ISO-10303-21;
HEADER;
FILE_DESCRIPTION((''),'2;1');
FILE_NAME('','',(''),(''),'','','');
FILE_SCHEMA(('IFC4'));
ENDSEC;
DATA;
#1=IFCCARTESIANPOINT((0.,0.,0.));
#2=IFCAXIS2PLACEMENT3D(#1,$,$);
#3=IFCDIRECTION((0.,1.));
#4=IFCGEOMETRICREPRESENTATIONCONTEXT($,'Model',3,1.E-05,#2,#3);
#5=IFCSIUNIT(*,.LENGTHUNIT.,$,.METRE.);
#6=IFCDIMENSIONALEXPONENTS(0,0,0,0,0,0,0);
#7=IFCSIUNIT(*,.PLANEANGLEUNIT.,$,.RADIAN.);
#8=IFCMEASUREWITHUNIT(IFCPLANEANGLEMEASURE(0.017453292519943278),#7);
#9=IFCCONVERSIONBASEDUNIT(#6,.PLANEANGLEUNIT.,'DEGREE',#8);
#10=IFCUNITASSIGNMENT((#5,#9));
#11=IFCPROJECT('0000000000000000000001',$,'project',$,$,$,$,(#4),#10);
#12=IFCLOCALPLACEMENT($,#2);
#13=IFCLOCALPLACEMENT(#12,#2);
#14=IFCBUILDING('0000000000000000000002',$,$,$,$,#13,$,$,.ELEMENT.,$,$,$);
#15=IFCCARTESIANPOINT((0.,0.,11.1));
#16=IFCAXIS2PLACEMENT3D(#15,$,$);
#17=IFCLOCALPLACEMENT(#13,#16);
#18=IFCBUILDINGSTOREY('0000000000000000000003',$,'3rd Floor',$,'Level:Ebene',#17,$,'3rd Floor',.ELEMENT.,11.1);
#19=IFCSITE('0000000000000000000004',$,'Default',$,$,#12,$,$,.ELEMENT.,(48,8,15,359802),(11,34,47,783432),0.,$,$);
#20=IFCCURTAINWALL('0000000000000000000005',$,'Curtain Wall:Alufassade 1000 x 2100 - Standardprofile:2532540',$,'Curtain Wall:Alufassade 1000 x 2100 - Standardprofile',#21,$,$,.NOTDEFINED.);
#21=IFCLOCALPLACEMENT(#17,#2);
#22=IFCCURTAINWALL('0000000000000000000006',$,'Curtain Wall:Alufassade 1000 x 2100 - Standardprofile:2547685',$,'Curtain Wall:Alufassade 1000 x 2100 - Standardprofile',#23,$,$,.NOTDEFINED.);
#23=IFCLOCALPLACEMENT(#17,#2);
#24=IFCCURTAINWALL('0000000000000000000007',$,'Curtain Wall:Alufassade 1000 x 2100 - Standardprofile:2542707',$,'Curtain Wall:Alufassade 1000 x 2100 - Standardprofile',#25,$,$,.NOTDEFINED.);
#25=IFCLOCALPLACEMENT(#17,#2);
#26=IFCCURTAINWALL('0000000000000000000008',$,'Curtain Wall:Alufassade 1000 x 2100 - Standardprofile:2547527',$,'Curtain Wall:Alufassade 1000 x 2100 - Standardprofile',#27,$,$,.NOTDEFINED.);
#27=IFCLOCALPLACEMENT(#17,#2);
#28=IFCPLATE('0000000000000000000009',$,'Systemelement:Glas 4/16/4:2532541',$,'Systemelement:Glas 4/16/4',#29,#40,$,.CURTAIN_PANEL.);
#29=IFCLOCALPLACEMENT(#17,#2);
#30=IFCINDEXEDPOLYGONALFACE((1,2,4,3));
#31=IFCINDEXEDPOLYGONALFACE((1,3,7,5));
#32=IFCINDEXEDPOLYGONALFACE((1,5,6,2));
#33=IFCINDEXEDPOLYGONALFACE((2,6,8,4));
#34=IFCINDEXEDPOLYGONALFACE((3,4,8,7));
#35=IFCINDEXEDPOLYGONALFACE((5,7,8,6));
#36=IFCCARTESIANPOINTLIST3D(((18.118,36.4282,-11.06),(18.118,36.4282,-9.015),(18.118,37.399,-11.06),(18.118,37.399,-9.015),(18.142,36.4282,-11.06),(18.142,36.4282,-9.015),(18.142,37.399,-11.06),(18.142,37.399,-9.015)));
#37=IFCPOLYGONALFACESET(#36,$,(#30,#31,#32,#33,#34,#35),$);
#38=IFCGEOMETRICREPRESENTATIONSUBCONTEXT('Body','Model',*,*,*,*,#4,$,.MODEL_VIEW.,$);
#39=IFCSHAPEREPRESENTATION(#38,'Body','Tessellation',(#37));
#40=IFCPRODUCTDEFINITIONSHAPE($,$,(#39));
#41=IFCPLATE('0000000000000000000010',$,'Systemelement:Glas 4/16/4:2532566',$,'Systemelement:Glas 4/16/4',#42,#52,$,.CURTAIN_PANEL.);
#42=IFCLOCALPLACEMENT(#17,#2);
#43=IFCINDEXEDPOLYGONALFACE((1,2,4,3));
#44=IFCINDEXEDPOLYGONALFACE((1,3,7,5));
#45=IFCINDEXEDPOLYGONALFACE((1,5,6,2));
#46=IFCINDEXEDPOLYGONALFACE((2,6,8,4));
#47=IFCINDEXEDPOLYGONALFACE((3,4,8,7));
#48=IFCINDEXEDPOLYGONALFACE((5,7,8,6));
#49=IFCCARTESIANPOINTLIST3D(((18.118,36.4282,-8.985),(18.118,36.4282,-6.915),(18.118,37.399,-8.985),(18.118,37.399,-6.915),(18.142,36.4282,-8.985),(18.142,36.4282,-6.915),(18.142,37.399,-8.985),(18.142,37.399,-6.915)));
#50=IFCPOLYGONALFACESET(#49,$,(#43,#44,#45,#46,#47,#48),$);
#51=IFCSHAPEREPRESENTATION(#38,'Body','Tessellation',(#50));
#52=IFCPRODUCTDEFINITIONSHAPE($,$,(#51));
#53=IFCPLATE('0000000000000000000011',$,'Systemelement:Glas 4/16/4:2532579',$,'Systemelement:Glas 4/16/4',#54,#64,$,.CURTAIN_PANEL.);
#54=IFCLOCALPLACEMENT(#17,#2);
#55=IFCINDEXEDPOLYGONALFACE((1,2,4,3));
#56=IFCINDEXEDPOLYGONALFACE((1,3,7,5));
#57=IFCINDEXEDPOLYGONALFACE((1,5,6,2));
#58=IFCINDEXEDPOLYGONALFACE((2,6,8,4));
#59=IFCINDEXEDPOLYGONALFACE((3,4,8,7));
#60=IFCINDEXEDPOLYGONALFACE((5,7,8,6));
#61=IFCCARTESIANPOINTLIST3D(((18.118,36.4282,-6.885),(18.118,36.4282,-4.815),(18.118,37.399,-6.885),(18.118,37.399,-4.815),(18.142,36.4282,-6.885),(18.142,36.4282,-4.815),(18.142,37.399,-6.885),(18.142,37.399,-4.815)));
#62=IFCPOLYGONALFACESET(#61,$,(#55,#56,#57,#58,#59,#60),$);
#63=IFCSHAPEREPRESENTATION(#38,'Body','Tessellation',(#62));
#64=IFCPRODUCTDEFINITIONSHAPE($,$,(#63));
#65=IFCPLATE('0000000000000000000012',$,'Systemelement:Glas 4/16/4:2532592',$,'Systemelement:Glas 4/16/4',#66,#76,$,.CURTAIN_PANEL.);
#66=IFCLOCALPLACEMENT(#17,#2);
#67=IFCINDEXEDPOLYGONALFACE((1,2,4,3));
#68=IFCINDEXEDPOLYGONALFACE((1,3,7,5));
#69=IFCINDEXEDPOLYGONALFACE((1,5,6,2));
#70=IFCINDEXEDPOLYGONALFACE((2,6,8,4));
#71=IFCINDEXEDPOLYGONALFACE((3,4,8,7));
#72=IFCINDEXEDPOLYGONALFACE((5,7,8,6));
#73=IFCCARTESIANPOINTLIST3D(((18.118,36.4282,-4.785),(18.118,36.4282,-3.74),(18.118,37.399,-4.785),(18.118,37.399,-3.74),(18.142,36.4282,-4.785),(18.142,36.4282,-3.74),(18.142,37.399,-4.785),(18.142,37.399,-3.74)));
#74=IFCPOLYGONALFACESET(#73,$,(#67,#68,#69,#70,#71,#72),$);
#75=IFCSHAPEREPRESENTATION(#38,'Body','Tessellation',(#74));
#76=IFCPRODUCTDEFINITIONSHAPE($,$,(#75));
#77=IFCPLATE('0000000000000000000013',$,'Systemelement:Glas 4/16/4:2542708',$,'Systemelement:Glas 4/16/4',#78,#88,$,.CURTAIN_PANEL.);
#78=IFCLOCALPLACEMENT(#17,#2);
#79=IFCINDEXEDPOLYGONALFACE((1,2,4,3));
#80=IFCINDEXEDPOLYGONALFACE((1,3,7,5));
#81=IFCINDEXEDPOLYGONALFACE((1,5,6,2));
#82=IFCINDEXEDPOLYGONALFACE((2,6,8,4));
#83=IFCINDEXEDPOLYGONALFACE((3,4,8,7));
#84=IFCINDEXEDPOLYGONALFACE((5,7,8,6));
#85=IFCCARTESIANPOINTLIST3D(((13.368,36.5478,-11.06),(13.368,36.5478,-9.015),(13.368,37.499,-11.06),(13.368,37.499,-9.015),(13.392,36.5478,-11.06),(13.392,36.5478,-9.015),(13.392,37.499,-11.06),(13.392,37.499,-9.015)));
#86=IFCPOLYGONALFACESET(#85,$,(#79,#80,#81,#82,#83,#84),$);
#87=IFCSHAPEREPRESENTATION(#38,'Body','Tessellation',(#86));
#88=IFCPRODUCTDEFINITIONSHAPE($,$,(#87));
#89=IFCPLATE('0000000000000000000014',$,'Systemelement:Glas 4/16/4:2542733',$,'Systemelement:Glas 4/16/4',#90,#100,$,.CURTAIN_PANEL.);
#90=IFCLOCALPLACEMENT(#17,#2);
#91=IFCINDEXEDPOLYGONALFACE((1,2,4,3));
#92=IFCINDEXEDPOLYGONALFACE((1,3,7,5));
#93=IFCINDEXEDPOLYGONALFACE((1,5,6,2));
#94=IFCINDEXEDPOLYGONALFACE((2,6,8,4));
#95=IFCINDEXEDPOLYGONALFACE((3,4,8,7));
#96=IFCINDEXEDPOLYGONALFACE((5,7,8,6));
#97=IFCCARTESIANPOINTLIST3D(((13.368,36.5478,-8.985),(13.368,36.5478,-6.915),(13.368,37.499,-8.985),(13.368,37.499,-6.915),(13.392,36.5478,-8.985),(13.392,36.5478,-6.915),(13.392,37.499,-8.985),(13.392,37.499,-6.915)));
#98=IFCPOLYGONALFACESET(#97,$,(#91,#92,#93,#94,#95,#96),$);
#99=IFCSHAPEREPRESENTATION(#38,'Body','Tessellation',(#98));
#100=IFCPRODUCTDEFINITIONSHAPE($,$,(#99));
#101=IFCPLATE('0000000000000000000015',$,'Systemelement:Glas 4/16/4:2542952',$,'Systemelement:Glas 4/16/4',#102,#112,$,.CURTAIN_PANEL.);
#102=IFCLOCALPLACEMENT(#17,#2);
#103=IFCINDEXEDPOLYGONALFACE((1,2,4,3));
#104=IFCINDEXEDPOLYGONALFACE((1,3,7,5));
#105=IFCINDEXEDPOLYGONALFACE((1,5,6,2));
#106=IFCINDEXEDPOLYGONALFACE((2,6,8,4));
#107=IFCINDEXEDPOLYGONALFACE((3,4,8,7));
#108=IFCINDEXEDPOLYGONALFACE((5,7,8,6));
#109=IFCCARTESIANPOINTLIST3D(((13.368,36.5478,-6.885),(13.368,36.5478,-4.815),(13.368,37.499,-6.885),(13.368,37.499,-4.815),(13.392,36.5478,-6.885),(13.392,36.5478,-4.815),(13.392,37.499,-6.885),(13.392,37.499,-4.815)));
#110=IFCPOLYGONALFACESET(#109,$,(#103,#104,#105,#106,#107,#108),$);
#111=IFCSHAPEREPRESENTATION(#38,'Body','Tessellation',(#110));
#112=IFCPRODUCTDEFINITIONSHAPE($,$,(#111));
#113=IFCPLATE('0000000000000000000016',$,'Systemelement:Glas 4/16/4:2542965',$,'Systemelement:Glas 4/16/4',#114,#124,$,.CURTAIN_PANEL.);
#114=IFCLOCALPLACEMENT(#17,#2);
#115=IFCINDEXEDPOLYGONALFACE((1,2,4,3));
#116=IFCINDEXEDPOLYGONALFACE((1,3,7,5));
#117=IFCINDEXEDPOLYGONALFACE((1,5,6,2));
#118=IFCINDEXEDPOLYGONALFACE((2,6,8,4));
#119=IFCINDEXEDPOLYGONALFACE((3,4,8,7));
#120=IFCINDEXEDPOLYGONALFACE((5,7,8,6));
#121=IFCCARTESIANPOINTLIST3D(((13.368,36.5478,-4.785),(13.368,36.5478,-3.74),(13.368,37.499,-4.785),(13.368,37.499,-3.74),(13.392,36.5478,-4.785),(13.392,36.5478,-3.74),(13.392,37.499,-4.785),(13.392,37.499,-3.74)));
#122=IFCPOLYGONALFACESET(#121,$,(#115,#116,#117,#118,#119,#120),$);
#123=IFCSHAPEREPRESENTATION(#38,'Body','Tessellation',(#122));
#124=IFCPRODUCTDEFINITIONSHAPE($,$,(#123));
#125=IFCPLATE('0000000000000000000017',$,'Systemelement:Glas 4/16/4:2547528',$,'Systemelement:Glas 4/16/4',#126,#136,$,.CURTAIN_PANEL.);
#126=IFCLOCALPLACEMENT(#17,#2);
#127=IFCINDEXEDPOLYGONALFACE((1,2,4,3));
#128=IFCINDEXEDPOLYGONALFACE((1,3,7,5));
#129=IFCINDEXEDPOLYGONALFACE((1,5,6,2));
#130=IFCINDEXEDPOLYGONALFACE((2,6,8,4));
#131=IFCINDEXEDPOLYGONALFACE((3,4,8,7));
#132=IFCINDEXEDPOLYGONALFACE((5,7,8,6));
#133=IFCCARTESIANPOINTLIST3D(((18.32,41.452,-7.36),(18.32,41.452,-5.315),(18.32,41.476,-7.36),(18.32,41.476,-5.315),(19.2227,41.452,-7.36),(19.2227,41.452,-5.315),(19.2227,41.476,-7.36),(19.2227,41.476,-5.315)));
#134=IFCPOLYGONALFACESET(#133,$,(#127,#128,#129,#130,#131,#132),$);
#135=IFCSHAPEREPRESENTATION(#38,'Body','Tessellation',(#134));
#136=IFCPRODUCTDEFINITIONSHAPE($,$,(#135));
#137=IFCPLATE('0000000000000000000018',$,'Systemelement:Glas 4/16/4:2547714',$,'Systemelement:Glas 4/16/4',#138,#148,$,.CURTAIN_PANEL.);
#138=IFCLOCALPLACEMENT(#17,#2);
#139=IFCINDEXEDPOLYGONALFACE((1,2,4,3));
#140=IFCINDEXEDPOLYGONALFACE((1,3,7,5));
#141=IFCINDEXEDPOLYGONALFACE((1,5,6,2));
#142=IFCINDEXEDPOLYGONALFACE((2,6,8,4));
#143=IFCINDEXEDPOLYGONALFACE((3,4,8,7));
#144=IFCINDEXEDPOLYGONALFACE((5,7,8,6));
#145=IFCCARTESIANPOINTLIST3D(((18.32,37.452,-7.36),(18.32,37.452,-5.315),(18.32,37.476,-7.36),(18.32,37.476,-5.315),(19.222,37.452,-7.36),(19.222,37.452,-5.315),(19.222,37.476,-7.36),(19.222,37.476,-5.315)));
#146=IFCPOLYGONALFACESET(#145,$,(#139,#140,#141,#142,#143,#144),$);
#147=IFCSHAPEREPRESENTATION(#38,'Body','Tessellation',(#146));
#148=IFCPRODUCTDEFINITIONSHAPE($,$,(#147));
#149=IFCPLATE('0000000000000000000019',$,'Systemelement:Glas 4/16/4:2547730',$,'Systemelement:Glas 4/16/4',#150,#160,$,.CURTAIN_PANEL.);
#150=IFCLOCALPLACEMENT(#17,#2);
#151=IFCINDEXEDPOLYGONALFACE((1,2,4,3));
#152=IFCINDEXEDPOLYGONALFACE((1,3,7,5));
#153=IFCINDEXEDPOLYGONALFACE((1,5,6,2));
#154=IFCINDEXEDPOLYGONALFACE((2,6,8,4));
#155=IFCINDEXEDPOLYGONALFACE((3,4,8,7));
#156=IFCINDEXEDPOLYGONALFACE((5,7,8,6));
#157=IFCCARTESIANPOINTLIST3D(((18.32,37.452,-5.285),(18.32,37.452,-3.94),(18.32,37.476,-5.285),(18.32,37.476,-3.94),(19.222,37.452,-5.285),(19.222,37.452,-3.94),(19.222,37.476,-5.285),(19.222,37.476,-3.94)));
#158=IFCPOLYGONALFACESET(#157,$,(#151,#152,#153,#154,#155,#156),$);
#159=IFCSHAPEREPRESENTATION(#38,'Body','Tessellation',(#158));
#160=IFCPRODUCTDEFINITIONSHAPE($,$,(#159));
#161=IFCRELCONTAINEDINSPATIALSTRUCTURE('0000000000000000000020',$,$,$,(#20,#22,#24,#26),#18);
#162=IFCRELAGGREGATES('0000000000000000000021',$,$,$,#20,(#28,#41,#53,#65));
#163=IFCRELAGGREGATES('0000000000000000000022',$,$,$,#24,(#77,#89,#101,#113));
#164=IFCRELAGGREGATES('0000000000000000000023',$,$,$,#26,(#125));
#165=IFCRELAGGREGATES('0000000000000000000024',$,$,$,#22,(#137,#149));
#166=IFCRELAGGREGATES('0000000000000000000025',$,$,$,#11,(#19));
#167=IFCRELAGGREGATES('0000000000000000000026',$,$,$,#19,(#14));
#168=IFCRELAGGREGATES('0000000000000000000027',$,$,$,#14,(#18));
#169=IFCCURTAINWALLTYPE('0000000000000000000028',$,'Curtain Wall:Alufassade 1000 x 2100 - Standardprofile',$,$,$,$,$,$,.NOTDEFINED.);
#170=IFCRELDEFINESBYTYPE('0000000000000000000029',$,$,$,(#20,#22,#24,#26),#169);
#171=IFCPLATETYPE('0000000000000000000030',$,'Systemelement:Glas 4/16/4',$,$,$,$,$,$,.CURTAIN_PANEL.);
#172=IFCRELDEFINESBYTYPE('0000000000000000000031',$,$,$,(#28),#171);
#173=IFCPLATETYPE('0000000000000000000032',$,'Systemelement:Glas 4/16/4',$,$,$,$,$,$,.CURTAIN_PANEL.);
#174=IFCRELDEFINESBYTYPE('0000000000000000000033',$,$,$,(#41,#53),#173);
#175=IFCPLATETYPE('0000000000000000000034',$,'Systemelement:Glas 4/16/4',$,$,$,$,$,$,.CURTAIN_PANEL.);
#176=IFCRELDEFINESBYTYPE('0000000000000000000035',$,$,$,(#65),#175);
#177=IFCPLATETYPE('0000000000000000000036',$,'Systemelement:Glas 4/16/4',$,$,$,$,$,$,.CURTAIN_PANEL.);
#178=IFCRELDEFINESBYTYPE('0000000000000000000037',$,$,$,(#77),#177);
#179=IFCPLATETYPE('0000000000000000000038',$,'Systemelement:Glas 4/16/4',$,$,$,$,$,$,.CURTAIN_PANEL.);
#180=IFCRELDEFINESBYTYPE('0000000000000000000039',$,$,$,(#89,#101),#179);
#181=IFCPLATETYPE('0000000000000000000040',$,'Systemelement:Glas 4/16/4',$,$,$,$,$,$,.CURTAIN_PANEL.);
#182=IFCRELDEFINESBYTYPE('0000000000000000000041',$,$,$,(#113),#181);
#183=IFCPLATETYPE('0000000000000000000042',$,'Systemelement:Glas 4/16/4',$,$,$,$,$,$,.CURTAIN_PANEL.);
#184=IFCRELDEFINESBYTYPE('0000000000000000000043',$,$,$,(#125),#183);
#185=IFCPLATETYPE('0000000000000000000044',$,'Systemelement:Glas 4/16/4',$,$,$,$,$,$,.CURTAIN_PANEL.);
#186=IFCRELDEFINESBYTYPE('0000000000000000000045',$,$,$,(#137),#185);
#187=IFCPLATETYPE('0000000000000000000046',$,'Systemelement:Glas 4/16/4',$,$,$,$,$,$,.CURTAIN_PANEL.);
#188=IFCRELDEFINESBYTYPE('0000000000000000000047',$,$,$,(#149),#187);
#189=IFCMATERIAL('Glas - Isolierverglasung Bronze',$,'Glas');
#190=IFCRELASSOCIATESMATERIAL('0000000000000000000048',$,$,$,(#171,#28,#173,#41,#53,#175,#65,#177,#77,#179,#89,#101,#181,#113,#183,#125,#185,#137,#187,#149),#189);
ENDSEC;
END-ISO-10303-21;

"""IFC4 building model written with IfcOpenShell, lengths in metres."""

from ifc_helpers import new_model, entity, si_unit, converted_unit, direction, frame, origin, place, context, subcontext, project, spatial, indexed_curve, outline, extrude, source, transform, mapped, material, type_object, type_shapes, element, aggregate, save


model = new_model("IFC4")

# Units and contexts
model_context = context("Model", 3, precision=1e-05, world=origin(), true_north=direction((0.0, 1.0)))
body_context = subcontext(model_context, "Body", "Model", "MODEL_VIEW")
ifc_project = project(units=[si_unit("LENGTHUNIT", "METRE"), converted_unit("PLANEANGLEUNIT", "DEGREE", entity("IfcPlaneAngleMeasure", 0.017453292519943278), si_unit("PLANEANGLEUNIT", "RADIAN"), dimensions=[0, 0, 0, 0, 0, 0, 0])], contexts=[model_context])

# Site, building, storey
site_placement = place(None, origin())
site = spatial("IfcSite", under=ifc_project, at=site_placement, Name="Default", CompositionType="ELEMENT", RefLatitude=(48, 8, 15, 359802), RefLongitude=(11, 34, 47, 783432), RefElevation=0.0)
building_placement = place(site_placement, origin())
building = spatial("IfcBuilding", under=site, at=building_placement, CompositionType="ELEMENT")
storey_placement = place(building_placement, frame((0.0, 0.0, 11.1)))
storey = spatial("IfcBuildingStorey", under=building, at=storey_placement, Name="3rd Floor", ObjectType="Level:Ebene", LongName="3rd Floor", CompositionType="ELEMENT", Elevation=11.1)

# Curtain walls
curtain_wall_type = type_object("IfcCurtainWallType", Name="Curtain Wall:Alufassade 1000 x 2100 - Standardprofile", PredefinedType="NOTDEFINED")
curtain_wall_1_placement = place(storey_placement, frame((0.0, 0.0, -11.1)))
curtain_wall_1 = element("IfcCurtainWall", 1, at=curtain_wall_1_placement, inside=storey, type_object=curtain_wall_type, Name="Curtain Wall:Alufassade 1000 x 2100 - Standardprofile:2532540", ObjectType="Curtain Wall:Alufassade 1000 x 2100 - Standardprofile", PredefinedType="NOTDEFINED")
curtain_wall_2_placement = place(storey_placement, frame((0.0, 0.0, -11.1)))
curtain_wall_2 = element("IfcCurtainWall", 2, at=curtain_wall_2_placement, inside=storey, type_object=curtain_wall_type, Name="Curtain Wall:Alufassade 1000 x 2100 - Standardprofile:2547685", ObjectType="Curtain Wall:Alufassade 1000 x 2100 - Standardprofile", PredefinedType="NOTDEFINED")

# Curtain walls
curtain_wall_3_placement = place(storey_placement, frame((0.0, 0.0, -11.1)))
curtain_wall_3 = element("IfcCurtainWall", 3, at=curtain_wall_3_placement, inside=storey, type_object=curtain_wall_type, Name="Curtain Wall:Alufassade 1000 x 2100 - Standardprofile:2542707", ObjectType="Curtain Wall:Alufassade 1000 x 2100 - Standardprofile", PredefinedType="NOTDEFINED")
curtain_wall_4_placement = place(storey_placement, frame((0.0, 0.0, -11.1)))
curtain_wall_4 = element("IfcCurtainWall", 4, at=curtain_wall_4_placement, inside=storey, type_object=curtain_wall_type, Name="Curtain Wall:Alufassade 1000 x 2100 - Standardprofile:2547527", ObjectType="Curtain Wall:Alufassade 1000 x 2100 - Standardprofile", PredefinedType="NOTDEFINED")

# Plates
ifc_material_1 = material(Name="Glas - Isolierverglasung Bronze", Category="Glas")
plate_type_1 = type_object("IfcPlateType", Name="Systemelement:Glas 4/16/4", PredefinedType="CURTAIN_PANEL", material=ifc_material_1)
shared_shape_1 = source(origin(), body_context, "Body", "SweptSolid", [
    extrude(outline(indexed_curve([(-0.012, -0.4854), (0.012, -0.4854), (0.012, 0.4854), (-0.012, 0.4854), (-0.012, -0.4854)], self_intersect=False)), frame((0.0, 0.0, 0.0), z_axis=(0.0, 0.0, 1.0), x_axis=(0.0, 1.0, 0.0)), (0.0, 0.0, 1.0), 2.045),
])
type_shapes(plate_type_1, [shared_shape_1])
plate_1_placement = place(curtain_wall_1_placement, frame((18.13, 36.9136, 0.04), z_axis=(0.0, 0.0, 1.0), x_axis=(0.0, -1.0, 0.0)))
plate_1 = element("IfcPlate", 5, at=plate_1_placement, type_object=plate_type_1, material=ifc_material_1, Name="Systemelement:Glas 4/16/4:2532541", ObjectType="Systemelement:Glas 4/16/4", PredefinedType="CURTAIN_PANEL", context=body_context, shape_type="MappedRepresentation", body=[
    mapped(shared_shape_1, transform((0.0, 0.0, 0.0), scale=1.0)),
])
plate_type_2 = type_object("IfcPlateType", Name="Systemelement:Glas 4/16/4", PredefinedType="CURTAIN_PANEL", material=ifc_material_1)
shared_shape_2 = source(origin(), body_context, "Body", "SweptSolid", [
    extrude(outline(indexed_curve([(-0.012, -0.4854), (0.012, -0.4854), (0.012, 0.4854), (-0.012, 0.4854), (-0.012, -0.4854)], self_intersect=False)), frame((0.0, 0.0, 0.0), z_axis=(0.0, 0.0, 1.0), x_axis=(0.0, 1.0, 0.0)), (0.0, 0.0, 1.0), 2.07),
])
type_shapes(plate_type_2, [shared_shape_2])
plate_2_placement = place(curtain_wall_1_placement, frame((18.13, 36.9136, 2.115), z_axis=(0.0, 0.0, 1.0), x_axis=(0.0, -1.0, 0.0)))
plate_2 = element("IfcPlate", 6, at=plate_2_placement, type_object=plate_type_2, material=ifc_material_1, Name="Systemelement:Glas 4/16/4:2532566", ObjectType="Systemelement:Glas 4/16/4", PredefinedType="CURTAIN_PANEL", context=body_context, shape_type="MappedRepresentation", body=[
    mapped(shared_shape_2, transform((0.0, 0.0, 0.0), scale=1.0)),
])
plate_3_placement = place(curtain_wall_1_placement, frame((18.13, 36.9136, 4.215), z_axis=(0.0, 0.0, 1.0), x_axis=(0.0, -1.0, 0.0)))
plate_3 = element("IfcPlate", 7, at=plate_3_placement, type_object=plate_type_2, material=ifc_material_1, Name="Systemelement:Glas 4/16/4:2532579", ObjectType="Systemelement:Glas 4/16/4", PredefinedType="CURTAIN_PANEL", context=body_context, shape_type="MappedRepresentation", body=[
    mapped(shared_shape_2, transform((0.0, 0.0, 0.0), scale=1.0)),
])
plate_type_3 = type_object("IfcPlateType", Name="Systemelement:Glas 4/16/4", PredefinedType="CURTAIN_PANEL", material=ifc_material_1)
shared_shape_3 = source(origin(), body_context, "Body", "SweptSolid", [
    extrude(outline(indexed_curve([(-0.012, -0.4854), (0.012, -0.4854), (0.012, 0.4854), (-0.012, 0.4854), (-0.012, -0.4854)], self_intersect=False)), frame((0.0, 0.0, 0.0), z_axis=(0.0, 0.0, 1.0), x_axis=(0.0, 1.0, 0.0)), (0.0, 0.0, 1.0), 1.045),
])
type_shapes(plate_type_3, [shared_shape_3])
plate_4_placement = place(curtain_wall_1_placement, frame((18.13, 36.9136, 6.315), z_axis=(0.0, 0.0, 1.0), x_axis=(0.0, -1.0, 0.0)))
plate_4 = element("IfcPlate", 8, at=plate_4_placement, type_object=plate_type_3, material=ifc_material_1, Name="Systemelement:Glas 4/16/4:2532592", ObjectType="Systemelement:Glas 4/16/4", PredefinedType="CURTAIN_PANEL", context=body_context, shape_type="MappedRepresentation", body=[
    mapped(shared_shape_3, transform((0.0, 0.0, 0.0), scale=1.0)),
])
aggregate(curtain_wall_1, [plate_1, plate_2, plate_3, plate_4])
plate_type_4 = type_object("IfcPlateType", Name="Systemelement:Glas 4/16/4", PredefinedType="CURTAIN_PANEL", material=ifc_material_1)
shared_shape_4 = source(origin(), body_context, "Body", "SweptSolid", [
    extrude(outline(indexed_curve([(-0.012, -0.4756), (0.012, -0.4756), (0.012, 0.4756), (-0.012, 0.4756), (-0.012, -0.4756)], self_intersect=False)), frame((0.0, 0.0, 0.0), z_axis=(0.0, 0.0, 1.0), x_axis=(0.0, 1.0, 0.0)), (0.0, 0.0, 1.0), 2.045),
])
type_shapes(plate_type_4, [shared_shape_4])
plate_5_placement = place(curtain_wall_3_placement, frame((13.38, 37.0234, 0.04), z_axis=(0.0, 0.0, 1.0), x_axis=(0.0, -1.0, 0.0)))
plate_5 = element("IfcPlate", 9, at=plate_5_placement, type_object=plate_type_4, material=ifc_material_1, Name="Systemelement:Glas 4/16/4:2542708", ObjectType="Systemelement:Glas 4/16/4", PredefinedType="CURTAIN_PANEL", context=body_context, shape_type="MappedRepresentation", body=[
    mapped(shared_shape_4, transform((0.0, 0.0, 0.0), scale=1.0)),
])
plate_type_5 = type_object("IfcPlateType", Name="Systemelement:Glas 4/16/4", PredefinedType="CURTAIN_PANEL", material=ifc_material_1)
shared_shape_5 = source(origin(), body_context, "Body", "SweptSolid", [
    extrude(outline(indexed_curve([(-0.012, -0.4756), (0.012, -0.4756), (0.012, 0.4756), (-0.012, 0.4756), (-0.012, -0.4756)], self_intersect=False)), frame((0.0, 0.0, 0.0), z_axis=(0.0, 0.0, 1.0), x_axis=(0.0, 1.0, 0.0)), (0.0, 0.0, 1.0), 2.07),
])
type_shapes(plate_type_5, [shared_shape_5])
plate_6_placement = place(curtain_wall_3_placement, frame((13.38, 37.0234, 2.115), z_axis=(0.0, 0.0, 1.0), x_axis=(0.0, -1.0, 0.0)))
plate_6 = element("IfcPlate", 10, at=plate_6_placement, type_object=plate_type_5, material=ifc_material_1, Name="Systemelement:Glas 4/16/4:2542733", ObjectType="Systemelement:Glas 4/16/4", PredefinedType="CURTAIN_PANEL", context=body_context, shape_type="MappedRepresentation", body=[
    mapped(shared_shape_5, transform((0.0, 0.0, 0.0), scale=1.0)),
])
plate_7_placement = place(curtain_wall_3_placement, frame((13.38, 37.0234, 4.215), z_axis=(0.0, 0.0, 1.0), x_axis=(0.0, -1.0, 0.0)))
plate_7 = element("IfcPlate", 11, at=plate_7_placement, type_object=plate_type_5, material=ifc_material_1, Name="Systemelement:Glas 4/16/4:2542952", ObjectType="Systemelement:Glas 4/16/4", PredefinedType="CURTAIN_PANEL", context=body_context, shape_type="MappedRepresentation", body=[
    mapped(shared_shape_5, transform((0.0, 0.0, 0.0), scale=1.0)),
])
plate_type_6 = type_object("IfcPlateType", Name="Systemelement:Glas 4/16/4", PredefinedType="CURTAIN_PANEL", material=ifc_material_1)
shared_shape_6 = source(origin(), body_context, "Body", "SweptSolid", [
    extrude(outline(indexed_curve([(-0.012, -0.4756), (0.012, -0.4756), (0.012, 0.4756), (-0.012, 0.4756), (-0.012, -0.4756)], self_intersect=False)), frame((0.0, 0.0, 0.0), z_axis=(0.0, 0.0, 1.0), x_axis=(0.0, 1.0, 0.0)), (0.0, 0.0, 1.0), 1.045),
])
type_shapes(plate_type_6, [shared_shape_6])
plate_8_placement = place(curtain_wall_3_placement, frame((13.38, 37.0234, 6.315), z_axis=(0.0, 0.0, 1.0), x_axis=(0.0, -1.0, 0.0)))
plate_8 = element("IfcPlate", 12, at=plate_8_placement, type_object=plate_type_6, material=ifc_material_1, Name="Systemelement:Glas 4/16/4:2542965", ObjectType="Systemelement:Glas 4/16/4", PredefinedType="CURTAIN_PANEL", context=body_context, shape_type="MappedRepresentation", body=[
    mapped(shared_shape_6, transform((0.0, 0.0, 0.0), scale=1.0)),
])
aggregate(curtain_wall_3, [plate_5, plate_6, plate_7, plate_8])
plate_type_7 = type_object("IfcPlateType", Name="Systemelement:Glas 4/16/4", PredefinedType="CURTAIN_PANEL", material=ifc_material_1)
shared_shape_7 = source(origin(), body_context, "Body", "SweptSolid", [
    extrude(outline(indexed_curve([(-0.012, -0.4513), (0.012, -0.4513), (0.012, 0.4513), (-0.012, 0.4513), (-0.012, -0.4513)], self_intersect=False)), frame((0.0, 0.0, 0.0), z_axis=(0.0, 0.0, 1.0), x_axis=(0.0, 1.0, 0.0)), (0.0, 0.0, 1.0), 2.045),
])
type_shapes(plate_type_7, [shared_shape_7])
plate_9_placement = place(curtain_wall_4_placement, frame((18.7713, 41.464, 3.74)))
plate_9 = element("IfcPlate", 13, at=plate_9_placement, type_object=plate_type_7, material=ifc_material_1, Name="Systemelement:Glas 4/16/4:2547528", ObjectType="Systemelement:Glas 4/16/4", PredefinedType="CURTAIN_PANEL", context=body_context, shape_type="MappedRepresentation", body=[
    mapped(shared_shape_7, transform((0.0, 0.0, 0.0), scale=1.0)),
])
aggregate(curtain_wall_4, [plate_9])
plate_type_8 = type_object("IfcPlateType", Name="Systemelement:Glas 4/16/4", PredefinedType="CURTAIN_PANEL", material=ifc_material_1)
shared_shape_8 = source(origin(), body_context, "Body", "SweptSolid", [
    extrude(outline(indexed_curve([(-0.012, -0.451), (0.012, -0.451), (0.012, 0.451), (-0.012, 0.451), (-0.012, -0.451)], self_intersect=False)), frame((0.0, 0.0, 0.0), z_axis=(0.0, 0.0, 1.0), x_axis=(0.0, 1.0, 0.0)), (0.0, 0.0, 1.0), 2.045),
])
type_shapes(plate_type_8, [shared_shape_8])
plate_10_placement = place(curtain_wall_2_placement, frame((18.771, 37.464, 3.74), z_axis=(0.0, 0.0, 1.0), x_axis=(-1.0, 0.0, 0.0)))
plate_10 = element("IfcPlate", 14, at=plate_10_placement, type_object=plate_type_8, material=ifc_material_1, Name="Systemelement:Glas 4/16/4:2547714", ObjectType="Systemelement:Glas 4/16/4", PredefinedType="CURTAIN_PANEL", context=body_context, shape_type="MappedRepresentation", body=[
    mapped(shared_shape_8, transform((0.0, 0.0, 0.0), scale=1.0)),
])
plate_type_9 = type_object("IfcPlateType", Name="Systemelement:Glas 4/16/4", PredefinedType="CURTAIN_PANEL", material=ifc_material_1)
shared_shape_9 = source(origin(), body_context, "Body", "SweptSolid", [
    extrude(outline(indexed_curve([(-0.012, -0.451), (0.012, -0.451), (0.012, 0.451), (-0.012, 0.451), (-0.012, -0.451)], self_intersect=False)), frame((0.0, 0.0, 0.0), z_axis=(0.0, 0.0, 1.0), x_axis=(0.0, 1.0, 0.0)), (0.0, 0.0, 1.0), 1.345),
])
type_shapes(plate_type_9, [shared_shape_9])
plate_11_placement = place(curtain_wall_2_placement, frame((18.771, 37.464, 5.815), z_axis=(0.0, 0.0, 1.0), x_axis=(-1.0, 0.0, 0.0)))
plate_11 = element("IfcPlate", 15, at=plate_11_placement, type_object=plate_type_9, material=ifc_material_1, Name="Systemelement:Glas 4/16/4:2547730", ObjectType="Systemelement:Glas 4/16/4", PredefinedType="CURTAIN_PANEL", context=body_context, shape_type="MappedRepresentation", body=[
    mapped(shared_shape_9, transform((0.0, 0.0, 0.0), scale=1.0)),
])
aggregate(curtain_wall_2, [plate_10, plate_11])

save(model, "model.ifc")
